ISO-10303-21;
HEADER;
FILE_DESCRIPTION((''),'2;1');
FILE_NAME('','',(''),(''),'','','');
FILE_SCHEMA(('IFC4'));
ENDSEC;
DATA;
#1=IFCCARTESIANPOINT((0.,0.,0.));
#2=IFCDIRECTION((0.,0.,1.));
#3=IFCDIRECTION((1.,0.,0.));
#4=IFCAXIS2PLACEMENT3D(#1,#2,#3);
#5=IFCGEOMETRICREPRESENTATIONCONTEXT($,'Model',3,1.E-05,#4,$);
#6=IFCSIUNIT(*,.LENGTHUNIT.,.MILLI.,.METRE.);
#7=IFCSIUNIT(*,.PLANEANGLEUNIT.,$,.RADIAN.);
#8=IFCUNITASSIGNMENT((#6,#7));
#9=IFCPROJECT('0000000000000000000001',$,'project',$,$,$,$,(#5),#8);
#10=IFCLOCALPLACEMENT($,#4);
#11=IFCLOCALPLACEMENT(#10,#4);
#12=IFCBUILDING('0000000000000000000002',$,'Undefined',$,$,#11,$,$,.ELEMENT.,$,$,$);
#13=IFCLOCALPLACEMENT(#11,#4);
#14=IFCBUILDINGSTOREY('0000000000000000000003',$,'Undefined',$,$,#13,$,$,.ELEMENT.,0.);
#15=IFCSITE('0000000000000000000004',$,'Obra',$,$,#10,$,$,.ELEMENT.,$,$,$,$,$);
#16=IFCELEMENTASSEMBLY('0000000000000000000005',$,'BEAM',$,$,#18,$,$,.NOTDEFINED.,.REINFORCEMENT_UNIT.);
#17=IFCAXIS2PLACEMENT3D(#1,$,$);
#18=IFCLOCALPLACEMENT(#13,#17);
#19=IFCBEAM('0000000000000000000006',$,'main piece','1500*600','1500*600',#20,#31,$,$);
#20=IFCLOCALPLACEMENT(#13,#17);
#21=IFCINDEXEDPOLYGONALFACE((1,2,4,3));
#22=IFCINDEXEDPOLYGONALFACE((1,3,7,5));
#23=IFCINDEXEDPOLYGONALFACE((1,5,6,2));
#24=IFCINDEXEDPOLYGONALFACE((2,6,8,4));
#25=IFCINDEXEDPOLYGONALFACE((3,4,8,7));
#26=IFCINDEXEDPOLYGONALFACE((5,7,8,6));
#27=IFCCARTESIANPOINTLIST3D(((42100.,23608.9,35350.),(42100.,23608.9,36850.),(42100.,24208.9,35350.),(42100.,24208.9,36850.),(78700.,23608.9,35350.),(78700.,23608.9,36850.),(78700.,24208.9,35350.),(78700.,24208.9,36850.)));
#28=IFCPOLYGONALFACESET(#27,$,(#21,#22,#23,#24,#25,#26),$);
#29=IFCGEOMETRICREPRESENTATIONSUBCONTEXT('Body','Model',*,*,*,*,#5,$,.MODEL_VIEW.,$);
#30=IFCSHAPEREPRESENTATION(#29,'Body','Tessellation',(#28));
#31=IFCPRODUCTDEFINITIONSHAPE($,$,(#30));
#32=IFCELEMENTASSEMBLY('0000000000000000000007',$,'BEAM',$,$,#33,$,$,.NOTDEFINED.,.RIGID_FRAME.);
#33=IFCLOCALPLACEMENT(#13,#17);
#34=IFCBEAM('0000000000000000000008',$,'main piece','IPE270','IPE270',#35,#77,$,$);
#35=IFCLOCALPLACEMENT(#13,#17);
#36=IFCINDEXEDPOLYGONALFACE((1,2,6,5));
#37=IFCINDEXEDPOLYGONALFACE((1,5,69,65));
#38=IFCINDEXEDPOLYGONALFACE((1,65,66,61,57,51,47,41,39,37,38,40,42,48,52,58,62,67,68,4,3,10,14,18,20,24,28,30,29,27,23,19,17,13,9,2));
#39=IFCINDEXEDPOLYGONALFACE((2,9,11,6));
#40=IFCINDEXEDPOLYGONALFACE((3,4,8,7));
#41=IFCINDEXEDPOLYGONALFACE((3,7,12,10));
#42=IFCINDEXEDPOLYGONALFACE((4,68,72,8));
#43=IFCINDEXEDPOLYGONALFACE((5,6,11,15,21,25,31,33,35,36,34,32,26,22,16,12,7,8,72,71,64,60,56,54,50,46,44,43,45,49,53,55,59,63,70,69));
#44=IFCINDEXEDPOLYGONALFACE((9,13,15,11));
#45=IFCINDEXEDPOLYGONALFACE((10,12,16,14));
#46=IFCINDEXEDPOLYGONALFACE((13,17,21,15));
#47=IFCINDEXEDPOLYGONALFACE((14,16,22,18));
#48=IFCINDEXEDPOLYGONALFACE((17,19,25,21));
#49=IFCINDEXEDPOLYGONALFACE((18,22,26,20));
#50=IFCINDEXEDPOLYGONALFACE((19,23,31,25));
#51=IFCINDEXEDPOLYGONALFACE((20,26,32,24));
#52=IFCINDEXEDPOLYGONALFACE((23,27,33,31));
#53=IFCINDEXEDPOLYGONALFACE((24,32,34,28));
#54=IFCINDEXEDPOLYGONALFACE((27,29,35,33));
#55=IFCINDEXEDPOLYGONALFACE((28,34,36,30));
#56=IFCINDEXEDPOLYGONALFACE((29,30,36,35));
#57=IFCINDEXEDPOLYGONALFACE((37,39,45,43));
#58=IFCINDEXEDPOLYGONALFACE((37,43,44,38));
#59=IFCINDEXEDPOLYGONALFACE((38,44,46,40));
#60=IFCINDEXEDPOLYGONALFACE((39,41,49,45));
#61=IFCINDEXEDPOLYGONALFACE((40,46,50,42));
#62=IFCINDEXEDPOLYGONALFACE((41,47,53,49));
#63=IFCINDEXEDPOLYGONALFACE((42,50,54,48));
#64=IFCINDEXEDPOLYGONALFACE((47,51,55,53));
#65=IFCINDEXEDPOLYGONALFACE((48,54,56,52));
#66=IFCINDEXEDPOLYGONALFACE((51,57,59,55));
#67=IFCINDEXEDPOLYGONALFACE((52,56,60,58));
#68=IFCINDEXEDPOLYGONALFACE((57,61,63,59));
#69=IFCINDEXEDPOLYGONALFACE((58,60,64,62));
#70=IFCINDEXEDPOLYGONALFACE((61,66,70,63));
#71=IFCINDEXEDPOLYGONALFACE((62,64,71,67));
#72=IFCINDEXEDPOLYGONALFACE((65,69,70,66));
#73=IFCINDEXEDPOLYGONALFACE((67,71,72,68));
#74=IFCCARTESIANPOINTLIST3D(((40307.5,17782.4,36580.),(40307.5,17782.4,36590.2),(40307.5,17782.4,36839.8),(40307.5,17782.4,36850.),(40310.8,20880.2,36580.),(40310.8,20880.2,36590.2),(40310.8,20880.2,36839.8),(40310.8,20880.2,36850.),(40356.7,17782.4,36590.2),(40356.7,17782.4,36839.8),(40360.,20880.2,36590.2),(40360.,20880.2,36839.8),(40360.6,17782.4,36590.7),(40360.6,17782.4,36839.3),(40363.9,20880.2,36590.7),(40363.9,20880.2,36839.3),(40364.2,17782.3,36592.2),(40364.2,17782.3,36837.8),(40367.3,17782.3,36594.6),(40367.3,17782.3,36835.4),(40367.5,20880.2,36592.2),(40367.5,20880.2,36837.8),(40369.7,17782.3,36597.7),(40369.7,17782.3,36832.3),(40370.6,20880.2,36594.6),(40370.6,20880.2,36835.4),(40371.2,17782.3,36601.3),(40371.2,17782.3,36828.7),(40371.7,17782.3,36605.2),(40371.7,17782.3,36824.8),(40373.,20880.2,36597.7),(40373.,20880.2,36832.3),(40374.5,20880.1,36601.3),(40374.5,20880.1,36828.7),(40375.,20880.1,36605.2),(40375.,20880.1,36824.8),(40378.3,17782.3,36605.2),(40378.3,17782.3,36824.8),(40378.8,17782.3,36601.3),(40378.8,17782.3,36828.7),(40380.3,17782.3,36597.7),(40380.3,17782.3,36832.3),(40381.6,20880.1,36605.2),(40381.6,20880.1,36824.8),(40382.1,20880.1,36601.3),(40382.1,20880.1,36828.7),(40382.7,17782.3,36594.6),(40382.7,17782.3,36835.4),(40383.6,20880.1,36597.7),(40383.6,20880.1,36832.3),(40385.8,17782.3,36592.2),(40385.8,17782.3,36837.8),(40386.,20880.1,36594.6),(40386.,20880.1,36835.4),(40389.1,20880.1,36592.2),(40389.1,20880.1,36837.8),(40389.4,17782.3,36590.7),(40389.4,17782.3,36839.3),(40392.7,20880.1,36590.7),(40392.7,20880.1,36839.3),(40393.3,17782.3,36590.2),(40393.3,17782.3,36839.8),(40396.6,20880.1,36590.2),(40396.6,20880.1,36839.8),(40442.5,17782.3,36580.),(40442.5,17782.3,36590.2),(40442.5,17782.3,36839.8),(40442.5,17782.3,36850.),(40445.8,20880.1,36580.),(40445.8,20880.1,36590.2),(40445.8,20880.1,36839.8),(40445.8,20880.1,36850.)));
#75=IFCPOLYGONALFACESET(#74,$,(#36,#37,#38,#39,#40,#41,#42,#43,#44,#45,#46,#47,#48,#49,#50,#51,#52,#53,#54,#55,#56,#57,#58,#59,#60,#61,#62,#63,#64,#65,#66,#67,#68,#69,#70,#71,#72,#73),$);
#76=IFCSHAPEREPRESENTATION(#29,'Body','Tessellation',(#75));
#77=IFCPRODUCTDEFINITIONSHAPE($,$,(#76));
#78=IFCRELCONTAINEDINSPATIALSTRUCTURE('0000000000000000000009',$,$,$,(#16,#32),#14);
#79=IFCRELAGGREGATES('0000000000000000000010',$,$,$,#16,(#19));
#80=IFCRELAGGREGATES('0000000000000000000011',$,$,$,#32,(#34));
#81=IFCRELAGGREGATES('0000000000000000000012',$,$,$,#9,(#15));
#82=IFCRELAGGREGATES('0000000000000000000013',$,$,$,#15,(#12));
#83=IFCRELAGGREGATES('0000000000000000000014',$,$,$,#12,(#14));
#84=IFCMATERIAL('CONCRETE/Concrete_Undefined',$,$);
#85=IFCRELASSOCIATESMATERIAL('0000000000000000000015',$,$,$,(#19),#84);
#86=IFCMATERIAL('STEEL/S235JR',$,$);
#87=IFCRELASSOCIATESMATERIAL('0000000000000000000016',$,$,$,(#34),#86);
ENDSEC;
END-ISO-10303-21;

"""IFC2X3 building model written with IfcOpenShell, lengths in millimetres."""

from ifc_helpers import new_model, si_unit, frame, origin_with_axes, origin_2d_with_axis, place, context, subcontext, project, spatial, rectangle, i_section, extrude, material, element, aggregate, save


model = new_model("IFC2X3")

# Units and contexts
model_context = context("Model", 3, precision=1e-05, world=origin_with_axes())
body_context = subcontext(model_context, "Body", "Model", "MODEL_VIEW")
ifc_project = project(units=[si_unit("LENGTHUNIT", "METRE", prefix="MILLI"), si_unit("PLANEANGLEUNIT", "RADIAN")], contexts=[model_context])

# Site, building, storey
site_placement = place(None, origin_with_axes())
site = spatial("IfcSite", under=ifc_project, at=site_placement, Name="Obra", CompositionType="ELEMENT")
building_placement = place(site_placement, origin_with_axes())
building = spatial("IfcBuilding", under=site, at=building_placement, Name="Undefined", CompositionType="ELEMENT")
storey_placement = place(building_placement, origin_with_axes())
storey = spatial("IfcBuildingStorey", under=building, at=storey_placement, Name="Undefined", CompositionType="ELEMENT", Elevation=0.0)

# Shared definitions
ifc_material_1 = material(Name="STEEL/S235JR")

# Element assembly, beam
assembly_1_placement = place(storey_placement, origin_with_axes())
assembly_1 = element("IfcElementAssembly", 1, at=assembly_1_placement, inside=storey, Name="BEAM", AssemblyPlace="NOTDEFINED", PredefinedType="REINFORCEMENT_UNIT")
ifc_material_2 = material(Name="CONCRETE/Concrete_Undefined")
beam_1_placement = place(assembly_1_placement, frame((42100.0, 23908.9, 36100.0), z_axis=(0.0, 0.0, 1.0), x_axis=(1.0, 0.0, 0.0)))
beam_1 = element("IfcBeam", 2, at=beam_1_placement, material=ifc_material_2, Name="main piece", Description="1500*600", ObjectType="1500*600", context=body_context, shape_type="SweptSolid", body=[
    extrude(rectangle(XDim=600.0, YDim=1500.0, at=origin_2d_with_axis()), frame((36600.0, 0.0, 0.0), z_axis=(-1.0, 0.0, 0.0), x_axis=(0.0, -1.0, 0.0)), (0.0, 0.0, 1.0), 36600.0),
])
aggregate(assembly_1, [beam_1])

# Element assembly, beam
assembly_2_placement = place(storey_placement, origin_with_axes())
assembly_2 = element("IfcElementAssembly", 3, at=assembly_2_placement, inside=storey, Name="BEAM", AssemblyPlace="NOTDEFINED", PredefinedType="RIGID_FRAME")
beam_2_placement = place(assembly_2_placement, frame((40375.0, 17782.3, 36715.0), z_axis=(0.0, 0.0, 1.0), x_axis=(0.001065, 0.999999, 0.0)))
beam_2 = element("IfcBeam", 4, at=beam_2_placement, material=ifc_material_1, Name="main piece", Description="IPE270", ObjectType="IPE270", context=body_context, shape_type="SweptSolid", body=[
    extrude(i_section(OverallWidth=135.0, OverallDepth=270.0, WebThickness=6.6, FlangeThickness=10.2, FilletRadius=15.0, at=origin_2d_with_axis()), frame((3097.8, 0.0, 0.0), z_axis=(-1.0, 0.0, 0.0), x_axis=(0.0, -1.0, 0.0)), (0.0, 0.0, 1.0), 3097.8),
])
aggregate(assembly_2, [beam_2])

save(model, "model.ifc")
